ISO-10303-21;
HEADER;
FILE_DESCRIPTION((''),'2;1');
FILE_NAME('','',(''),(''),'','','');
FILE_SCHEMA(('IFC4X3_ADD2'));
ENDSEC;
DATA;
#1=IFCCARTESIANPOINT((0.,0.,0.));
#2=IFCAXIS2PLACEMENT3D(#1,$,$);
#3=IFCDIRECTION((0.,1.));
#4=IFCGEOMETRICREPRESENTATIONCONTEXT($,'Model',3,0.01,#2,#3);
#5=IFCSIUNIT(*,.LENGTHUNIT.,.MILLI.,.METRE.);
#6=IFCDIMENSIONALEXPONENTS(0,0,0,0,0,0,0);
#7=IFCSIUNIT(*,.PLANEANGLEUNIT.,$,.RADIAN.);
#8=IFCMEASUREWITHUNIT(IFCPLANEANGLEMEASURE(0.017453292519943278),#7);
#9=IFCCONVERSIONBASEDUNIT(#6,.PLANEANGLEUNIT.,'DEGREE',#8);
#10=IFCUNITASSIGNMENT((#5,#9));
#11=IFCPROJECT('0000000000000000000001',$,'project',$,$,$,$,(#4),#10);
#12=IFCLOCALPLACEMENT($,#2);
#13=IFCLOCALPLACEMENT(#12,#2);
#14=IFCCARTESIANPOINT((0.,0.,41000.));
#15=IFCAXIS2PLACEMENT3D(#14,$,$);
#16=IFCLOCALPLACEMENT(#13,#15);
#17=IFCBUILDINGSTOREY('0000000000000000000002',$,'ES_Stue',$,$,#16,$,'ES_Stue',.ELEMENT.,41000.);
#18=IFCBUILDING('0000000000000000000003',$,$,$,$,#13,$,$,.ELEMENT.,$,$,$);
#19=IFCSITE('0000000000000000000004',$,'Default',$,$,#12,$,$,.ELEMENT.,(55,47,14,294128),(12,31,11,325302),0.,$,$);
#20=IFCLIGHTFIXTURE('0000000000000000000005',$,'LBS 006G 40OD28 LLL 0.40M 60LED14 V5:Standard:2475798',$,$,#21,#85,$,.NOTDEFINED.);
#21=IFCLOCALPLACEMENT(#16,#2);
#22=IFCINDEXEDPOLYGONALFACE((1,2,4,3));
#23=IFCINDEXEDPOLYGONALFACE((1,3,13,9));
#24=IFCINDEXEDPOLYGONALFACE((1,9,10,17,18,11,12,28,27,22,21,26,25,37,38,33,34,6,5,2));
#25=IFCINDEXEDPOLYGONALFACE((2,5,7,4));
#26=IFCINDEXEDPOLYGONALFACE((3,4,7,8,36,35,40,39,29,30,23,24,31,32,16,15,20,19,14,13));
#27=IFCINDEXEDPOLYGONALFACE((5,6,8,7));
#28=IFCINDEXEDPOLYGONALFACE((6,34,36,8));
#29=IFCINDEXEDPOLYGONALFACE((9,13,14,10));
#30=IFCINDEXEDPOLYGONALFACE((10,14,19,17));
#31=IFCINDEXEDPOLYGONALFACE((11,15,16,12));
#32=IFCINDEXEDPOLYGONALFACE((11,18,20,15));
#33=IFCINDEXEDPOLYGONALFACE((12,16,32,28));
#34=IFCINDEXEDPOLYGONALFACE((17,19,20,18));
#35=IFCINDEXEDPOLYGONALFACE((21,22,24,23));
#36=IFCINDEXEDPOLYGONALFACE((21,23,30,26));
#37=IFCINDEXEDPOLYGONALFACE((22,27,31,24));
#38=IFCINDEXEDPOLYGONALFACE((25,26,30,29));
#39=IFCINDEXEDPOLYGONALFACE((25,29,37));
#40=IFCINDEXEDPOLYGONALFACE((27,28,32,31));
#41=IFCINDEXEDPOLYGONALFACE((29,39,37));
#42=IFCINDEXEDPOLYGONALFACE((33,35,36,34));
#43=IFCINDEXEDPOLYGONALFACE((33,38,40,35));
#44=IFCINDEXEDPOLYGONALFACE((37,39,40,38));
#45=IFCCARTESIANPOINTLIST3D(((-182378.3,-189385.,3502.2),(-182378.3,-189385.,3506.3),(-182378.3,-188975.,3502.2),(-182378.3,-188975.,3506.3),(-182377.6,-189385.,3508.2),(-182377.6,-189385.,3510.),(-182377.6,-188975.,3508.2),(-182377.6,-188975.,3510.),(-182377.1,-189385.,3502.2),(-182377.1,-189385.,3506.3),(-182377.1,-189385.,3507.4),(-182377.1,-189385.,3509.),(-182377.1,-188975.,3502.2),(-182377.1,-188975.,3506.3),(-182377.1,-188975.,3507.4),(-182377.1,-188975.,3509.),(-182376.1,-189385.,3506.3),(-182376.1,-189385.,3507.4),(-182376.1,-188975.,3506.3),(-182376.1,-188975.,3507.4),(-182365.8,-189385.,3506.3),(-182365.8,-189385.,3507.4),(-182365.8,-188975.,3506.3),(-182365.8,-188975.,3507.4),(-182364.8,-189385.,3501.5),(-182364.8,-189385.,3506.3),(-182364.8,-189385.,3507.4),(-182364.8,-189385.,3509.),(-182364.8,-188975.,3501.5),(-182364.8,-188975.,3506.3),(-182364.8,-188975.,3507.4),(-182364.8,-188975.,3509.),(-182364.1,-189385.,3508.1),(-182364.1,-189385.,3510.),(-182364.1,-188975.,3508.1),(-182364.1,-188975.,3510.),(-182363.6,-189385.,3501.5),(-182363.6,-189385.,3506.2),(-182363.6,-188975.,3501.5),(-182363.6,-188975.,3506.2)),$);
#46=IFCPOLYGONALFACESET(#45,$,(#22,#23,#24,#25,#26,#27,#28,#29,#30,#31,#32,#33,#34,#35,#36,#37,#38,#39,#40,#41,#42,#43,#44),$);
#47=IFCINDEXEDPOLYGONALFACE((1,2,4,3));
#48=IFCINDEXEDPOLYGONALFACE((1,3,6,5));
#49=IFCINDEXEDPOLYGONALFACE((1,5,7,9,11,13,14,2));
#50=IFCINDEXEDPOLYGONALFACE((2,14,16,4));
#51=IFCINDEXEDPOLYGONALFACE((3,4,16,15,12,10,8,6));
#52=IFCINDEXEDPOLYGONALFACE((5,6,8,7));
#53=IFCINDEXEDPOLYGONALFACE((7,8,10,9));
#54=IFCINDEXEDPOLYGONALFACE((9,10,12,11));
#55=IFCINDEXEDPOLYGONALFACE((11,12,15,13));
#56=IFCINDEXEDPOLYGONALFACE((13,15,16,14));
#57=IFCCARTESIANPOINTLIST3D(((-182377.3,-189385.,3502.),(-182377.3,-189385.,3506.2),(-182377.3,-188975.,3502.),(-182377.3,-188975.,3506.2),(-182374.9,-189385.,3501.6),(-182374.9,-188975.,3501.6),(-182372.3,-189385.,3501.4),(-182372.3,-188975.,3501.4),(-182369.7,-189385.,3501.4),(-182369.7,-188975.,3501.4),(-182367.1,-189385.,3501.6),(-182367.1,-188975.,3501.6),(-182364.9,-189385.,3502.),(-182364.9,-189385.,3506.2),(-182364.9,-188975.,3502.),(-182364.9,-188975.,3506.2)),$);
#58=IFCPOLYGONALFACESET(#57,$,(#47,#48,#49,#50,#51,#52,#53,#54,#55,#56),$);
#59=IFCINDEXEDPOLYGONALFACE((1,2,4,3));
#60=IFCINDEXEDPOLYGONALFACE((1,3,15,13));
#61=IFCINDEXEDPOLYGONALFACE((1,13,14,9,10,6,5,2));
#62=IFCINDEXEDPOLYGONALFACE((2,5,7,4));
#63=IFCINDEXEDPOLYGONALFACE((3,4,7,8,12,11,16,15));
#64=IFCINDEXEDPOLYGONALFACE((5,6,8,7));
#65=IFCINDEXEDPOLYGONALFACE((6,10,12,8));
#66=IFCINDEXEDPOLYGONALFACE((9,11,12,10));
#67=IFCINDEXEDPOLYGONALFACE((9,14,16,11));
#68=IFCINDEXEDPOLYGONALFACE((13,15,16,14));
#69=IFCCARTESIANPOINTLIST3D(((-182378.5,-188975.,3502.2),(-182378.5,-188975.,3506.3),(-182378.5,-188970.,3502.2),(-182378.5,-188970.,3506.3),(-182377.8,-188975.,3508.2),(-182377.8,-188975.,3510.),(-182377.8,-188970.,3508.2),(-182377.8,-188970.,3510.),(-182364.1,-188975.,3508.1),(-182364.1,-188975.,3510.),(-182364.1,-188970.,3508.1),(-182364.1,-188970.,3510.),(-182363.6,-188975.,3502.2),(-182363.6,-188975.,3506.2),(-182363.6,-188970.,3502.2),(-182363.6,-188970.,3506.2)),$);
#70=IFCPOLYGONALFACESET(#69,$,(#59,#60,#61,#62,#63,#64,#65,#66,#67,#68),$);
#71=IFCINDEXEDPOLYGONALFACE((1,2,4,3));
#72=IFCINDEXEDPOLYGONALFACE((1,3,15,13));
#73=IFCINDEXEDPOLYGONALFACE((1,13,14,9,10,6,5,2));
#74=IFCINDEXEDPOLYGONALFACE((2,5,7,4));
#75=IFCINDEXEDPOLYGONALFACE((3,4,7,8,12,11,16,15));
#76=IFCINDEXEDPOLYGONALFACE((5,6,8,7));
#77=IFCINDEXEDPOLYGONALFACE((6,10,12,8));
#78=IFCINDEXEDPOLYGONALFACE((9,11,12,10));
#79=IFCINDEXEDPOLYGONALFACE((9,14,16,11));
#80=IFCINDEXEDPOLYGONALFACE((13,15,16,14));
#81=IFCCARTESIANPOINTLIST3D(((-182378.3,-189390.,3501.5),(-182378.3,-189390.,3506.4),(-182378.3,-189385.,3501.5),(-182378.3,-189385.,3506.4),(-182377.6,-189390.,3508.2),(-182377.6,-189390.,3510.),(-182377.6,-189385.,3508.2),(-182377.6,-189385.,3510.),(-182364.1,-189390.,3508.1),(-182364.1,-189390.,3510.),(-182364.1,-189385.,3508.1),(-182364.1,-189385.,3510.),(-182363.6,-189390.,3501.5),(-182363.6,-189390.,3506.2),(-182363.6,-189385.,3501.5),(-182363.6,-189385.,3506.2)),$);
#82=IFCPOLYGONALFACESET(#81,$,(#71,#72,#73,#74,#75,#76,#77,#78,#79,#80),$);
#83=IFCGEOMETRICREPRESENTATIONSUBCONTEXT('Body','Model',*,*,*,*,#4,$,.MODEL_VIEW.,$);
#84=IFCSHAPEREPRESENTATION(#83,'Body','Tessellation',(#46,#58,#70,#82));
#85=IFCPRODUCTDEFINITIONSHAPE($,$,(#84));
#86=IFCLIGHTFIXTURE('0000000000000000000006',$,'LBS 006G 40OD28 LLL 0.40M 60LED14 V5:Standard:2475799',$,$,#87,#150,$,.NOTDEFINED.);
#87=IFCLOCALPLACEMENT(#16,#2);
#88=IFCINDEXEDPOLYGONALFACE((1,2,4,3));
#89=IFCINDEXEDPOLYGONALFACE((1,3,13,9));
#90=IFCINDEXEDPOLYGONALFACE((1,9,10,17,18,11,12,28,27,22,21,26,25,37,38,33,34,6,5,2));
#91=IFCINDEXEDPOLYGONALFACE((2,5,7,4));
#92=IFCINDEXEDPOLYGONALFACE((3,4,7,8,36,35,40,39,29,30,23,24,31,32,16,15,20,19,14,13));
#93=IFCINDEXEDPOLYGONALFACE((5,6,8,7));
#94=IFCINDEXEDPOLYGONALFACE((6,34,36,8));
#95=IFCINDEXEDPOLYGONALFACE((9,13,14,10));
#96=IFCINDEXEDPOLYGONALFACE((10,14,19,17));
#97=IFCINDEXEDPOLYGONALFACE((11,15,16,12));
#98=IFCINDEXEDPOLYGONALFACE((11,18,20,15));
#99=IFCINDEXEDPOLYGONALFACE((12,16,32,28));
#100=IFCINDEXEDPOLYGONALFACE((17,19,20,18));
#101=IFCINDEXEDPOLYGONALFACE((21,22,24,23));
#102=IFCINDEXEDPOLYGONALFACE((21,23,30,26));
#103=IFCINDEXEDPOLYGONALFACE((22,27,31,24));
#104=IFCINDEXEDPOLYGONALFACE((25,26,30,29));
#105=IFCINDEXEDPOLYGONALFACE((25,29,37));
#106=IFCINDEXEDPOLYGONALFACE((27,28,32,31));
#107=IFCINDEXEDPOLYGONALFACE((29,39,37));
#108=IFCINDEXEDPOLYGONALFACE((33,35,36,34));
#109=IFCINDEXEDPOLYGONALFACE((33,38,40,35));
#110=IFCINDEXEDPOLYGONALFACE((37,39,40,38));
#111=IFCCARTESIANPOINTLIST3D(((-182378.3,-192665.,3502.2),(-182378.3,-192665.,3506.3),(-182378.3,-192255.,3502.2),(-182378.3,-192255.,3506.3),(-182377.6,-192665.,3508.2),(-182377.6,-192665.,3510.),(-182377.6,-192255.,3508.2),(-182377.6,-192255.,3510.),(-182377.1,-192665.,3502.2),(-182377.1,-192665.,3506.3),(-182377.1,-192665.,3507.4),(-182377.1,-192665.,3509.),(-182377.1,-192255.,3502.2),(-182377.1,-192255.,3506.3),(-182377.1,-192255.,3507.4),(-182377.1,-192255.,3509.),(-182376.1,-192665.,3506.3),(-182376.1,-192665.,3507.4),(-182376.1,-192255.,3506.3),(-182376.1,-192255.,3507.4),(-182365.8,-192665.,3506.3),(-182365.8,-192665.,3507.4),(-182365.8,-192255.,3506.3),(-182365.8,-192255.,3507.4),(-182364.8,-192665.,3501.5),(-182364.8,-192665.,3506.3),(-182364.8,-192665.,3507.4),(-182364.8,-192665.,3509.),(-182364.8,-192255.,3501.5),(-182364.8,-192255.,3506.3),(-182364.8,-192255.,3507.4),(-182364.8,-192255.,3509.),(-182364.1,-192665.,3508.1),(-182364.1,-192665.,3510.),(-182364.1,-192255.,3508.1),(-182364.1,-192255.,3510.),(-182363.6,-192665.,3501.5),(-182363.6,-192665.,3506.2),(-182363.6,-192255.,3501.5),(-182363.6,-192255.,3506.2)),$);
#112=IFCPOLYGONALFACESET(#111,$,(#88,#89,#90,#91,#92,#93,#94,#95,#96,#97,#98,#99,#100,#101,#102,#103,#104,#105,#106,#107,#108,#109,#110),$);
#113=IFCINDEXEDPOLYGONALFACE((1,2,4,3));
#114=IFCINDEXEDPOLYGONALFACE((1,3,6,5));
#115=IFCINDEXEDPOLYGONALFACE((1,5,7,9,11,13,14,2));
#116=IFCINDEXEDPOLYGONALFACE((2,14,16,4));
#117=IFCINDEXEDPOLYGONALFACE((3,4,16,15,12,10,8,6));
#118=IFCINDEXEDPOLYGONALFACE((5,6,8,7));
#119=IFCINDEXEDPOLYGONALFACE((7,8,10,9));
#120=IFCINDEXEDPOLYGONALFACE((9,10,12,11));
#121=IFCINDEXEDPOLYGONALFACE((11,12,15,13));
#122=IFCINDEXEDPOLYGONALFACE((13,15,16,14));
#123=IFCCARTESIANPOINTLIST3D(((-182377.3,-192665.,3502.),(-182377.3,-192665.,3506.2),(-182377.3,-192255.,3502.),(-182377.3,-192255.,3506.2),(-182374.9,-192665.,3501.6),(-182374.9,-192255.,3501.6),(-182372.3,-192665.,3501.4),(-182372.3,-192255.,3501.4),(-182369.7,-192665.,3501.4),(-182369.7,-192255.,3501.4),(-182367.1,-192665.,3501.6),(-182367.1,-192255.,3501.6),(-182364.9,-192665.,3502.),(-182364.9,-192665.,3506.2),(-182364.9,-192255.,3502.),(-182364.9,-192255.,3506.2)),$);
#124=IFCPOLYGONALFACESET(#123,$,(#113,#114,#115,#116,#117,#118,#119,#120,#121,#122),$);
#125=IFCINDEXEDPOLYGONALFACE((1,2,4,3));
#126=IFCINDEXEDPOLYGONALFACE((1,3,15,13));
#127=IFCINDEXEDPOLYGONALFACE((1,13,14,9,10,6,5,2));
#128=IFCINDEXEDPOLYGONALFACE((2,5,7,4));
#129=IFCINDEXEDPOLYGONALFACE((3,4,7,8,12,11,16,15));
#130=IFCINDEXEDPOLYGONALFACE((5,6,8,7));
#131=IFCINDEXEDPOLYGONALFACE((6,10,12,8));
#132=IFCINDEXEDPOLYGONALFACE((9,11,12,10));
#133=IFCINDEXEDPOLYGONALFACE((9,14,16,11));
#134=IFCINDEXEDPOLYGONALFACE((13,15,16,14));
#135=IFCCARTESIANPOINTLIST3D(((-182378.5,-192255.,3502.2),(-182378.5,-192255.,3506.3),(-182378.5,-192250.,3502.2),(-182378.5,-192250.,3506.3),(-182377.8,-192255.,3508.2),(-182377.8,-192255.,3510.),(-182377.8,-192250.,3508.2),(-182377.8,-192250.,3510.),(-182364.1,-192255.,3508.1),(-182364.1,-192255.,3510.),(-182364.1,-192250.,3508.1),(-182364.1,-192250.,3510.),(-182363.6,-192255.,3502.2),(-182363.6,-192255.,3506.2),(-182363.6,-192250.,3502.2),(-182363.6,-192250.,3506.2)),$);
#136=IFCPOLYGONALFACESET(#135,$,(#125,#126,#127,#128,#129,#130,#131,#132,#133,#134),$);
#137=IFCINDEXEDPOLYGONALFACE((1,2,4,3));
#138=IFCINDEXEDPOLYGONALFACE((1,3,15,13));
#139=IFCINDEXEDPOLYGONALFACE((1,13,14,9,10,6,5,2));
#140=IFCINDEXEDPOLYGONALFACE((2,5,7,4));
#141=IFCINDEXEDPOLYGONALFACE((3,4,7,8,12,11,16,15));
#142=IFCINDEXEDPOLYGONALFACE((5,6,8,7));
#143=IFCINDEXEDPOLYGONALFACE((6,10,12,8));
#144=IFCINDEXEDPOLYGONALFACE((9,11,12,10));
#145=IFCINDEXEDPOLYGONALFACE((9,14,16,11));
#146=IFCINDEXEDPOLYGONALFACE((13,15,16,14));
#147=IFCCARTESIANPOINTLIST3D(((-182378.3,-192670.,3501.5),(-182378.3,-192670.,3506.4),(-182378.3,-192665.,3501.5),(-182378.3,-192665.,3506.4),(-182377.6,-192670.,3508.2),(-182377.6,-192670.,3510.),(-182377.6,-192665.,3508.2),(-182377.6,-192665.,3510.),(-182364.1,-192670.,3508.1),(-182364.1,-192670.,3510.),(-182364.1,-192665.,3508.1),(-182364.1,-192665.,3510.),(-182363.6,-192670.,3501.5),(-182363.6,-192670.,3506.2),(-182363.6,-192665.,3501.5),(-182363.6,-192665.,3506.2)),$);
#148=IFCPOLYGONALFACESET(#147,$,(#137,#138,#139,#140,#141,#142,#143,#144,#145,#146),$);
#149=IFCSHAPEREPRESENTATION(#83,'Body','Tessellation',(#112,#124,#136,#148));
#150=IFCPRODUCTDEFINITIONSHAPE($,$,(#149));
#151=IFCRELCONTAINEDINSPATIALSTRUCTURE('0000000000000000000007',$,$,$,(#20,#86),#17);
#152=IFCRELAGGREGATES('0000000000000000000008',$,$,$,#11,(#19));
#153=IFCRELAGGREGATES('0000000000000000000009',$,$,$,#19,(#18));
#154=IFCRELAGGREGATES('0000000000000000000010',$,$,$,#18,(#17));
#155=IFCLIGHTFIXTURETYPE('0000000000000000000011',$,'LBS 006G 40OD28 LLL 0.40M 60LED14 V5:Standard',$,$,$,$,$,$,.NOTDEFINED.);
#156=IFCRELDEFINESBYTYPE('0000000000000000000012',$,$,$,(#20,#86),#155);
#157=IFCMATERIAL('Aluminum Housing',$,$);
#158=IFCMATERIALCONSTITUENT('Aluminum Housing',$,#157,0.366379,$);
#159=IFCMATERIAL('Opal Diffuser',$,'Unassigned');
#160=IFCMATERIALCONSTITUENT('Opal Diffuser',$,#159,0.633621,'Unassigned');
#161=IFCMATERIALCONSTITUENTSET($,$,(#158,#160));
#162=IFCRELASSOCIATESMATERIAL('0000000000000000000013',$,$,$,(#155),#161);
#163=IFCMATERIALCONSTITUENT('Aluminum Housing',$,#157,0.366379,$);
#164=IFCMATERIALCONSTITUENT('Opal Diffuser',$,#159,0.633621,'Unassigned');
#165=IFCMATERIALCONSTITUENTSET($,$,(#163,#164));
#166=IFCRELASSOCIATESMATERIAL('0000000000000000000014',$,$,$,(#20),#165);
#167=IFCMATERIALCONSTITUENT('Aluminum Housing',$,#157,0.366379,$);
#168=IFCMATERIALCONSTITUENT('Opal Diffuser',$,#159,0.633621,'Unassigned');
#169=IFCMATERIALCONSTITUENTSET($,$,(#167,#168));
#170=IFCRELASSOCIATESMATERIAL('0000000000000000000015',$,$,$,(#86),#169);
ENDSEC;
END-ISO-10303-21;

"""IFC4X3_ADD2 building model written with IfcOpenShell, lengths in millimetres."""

from ifc_helpers import new_model, entity, si_unit, converted_unit, direction, frame, origin, place, context, subcontext, project, spatial, polyline, outline, extrude, source, transform, mapped, material, constituent, constituent_set, type_object, type_shapes, element, save


model = new_model("IFC4X3_ADD2")

# Units and contexts
model_context = context("Model", 3, precision=0.01, world=origin(), true_north=direction((0.0, 1.0)))
body_context = subcontext(model_context, "Body", "Model", "MODEL_VIEW")
ifc_project = project(units=[si_unit("LENGTHUNIT", "METRE", prefix="MILLI"), converted_unit("PLANEANGLEUNIT", "DEGREE", entity("IfcPlaneAngleMeasure", 0.017453292519943278), si_unit("PLANEANGLEUNIT", "RADIAN"), dimensions=[0, 0, 0, 0, 0, 0, 0])], contexts=[model_context])

# Site, building, storey
site_placement = place(None, origin())
site = spatial("IfcSite", under=ifc_project, at=site_placement, Name="Default", CompositionType="ELEMENT", RefLatitude=(55, 47, 14, 294128), RefLongitude=(12, 31, 11, 325302), RefElevation=0.0)
building_placement = place(site_placement, origin())
building = spatial("IfcBuilding", under=site, at=building_placement, CompositionType="ELEMENT")
storey_placement = place(building_placement, frame((0.0, 0.0, 41000.0)))
storey = spatial("IfcBuildingStorey", under=building, at=storey_placement, Name="ES_Stue", LongName="ES_Stue", CompositionType="ELEMENT", Elevation=41000.0)

# Light fixtures
ifc_material_1 = material(Name="Aluminum Housing")
ifc_material_2 = material(Name="Opal Diffuser", Category="Unassigned")
ifc_constituent_1 = constituent(ifc_material_1, Name="Aluminum Housing", fraction=0.366379)
ifc_constituent_2 = constituent(ifc_material_2, Name="Opal Diffuser", Category="Unassigned", fraction=0.633621)
ifc_constituent_set_1 = constituent_set(constituents=[ifc_constituent_1, ifc_constituent_2])
light_fixture_type = type_object("IfcLightFixtureType", Name="LBS 006G 40OD28 LLL 0.40M 60LED14 V5:Standard", PredefinedType="NOTDEFINED", material=ifc_constituent_set_1)
shared_shape_1 = source(origin(), body_context, "Body", "SweptSolid", [
    extrude(outline(polyline([(-5.0, -6.1), (-5.0, -7.4), (-0.3, -7.4), (1.7, -6.8), (3.5, -6.8), (3.5, 6.7), (1.8, 6.7), (-0.1, 7.3), (-4.2, 7.3), (-4.2, 6.2), (-0.1, 6.2), (-0.1, 5.2), (0.9, 5.2), (0.9, 6.2), (2.5, 6.2), (2.5, -6.1), (0.9, -6.1), (0.9, -5.1), (-0.1, -5.1), (-0.1, -6.1), (-5.0, -6.1)])), frame((-205.0, 0.1, 3.5), z_axis=(-1.0, 0.0, 0.0), x_axis=(0.0, 0.0, -1.0)), (0.0, 0.0, -1.0), 410.0),
    extrude(outline(polyline([(-0.8, -6.2), (3.4, -6.2), (3.4, 6.2), (-0.8, 6.2), (-1.2, 3.9), (-1.4, 1.4), (-1.4, -1.3), (-1.2, -3.9), (-0.8, -6.2)])), frame((-205.0, 0.0, 7.2), z_axis=(1.0, 0.0, 0.0), x_axis=(0.0, 0.0, -1.0)), (0.0, 0.0, 1.0), 410.0),
    extrude(outline(polyline([(-4.4, -7.5), (-0.3, -7.5), (1.5, -6.8), (3.3, -6.8), (3.3, 6.9), (1.5, 6.9), (-0.5, 7.4), (-4.4, 7.4), (-4.4, -7.5)])), frame((205.0, 0.0, 3.3), z_axis=(1.0, 0.0, 0.0), x_axis=(0.0, 0.0, -1.0)), (0.0, 0.0, 1.0), 5.0),
    extrude(outline(polyline([(-5.0, -7.4), (-0.1, -7.4), (1.7, -6.7), (3.5, -6.7), (3.5, 6.8), (1.6, 6.8), (-0.3, 7.3), (-5.0, 7.3), (-5.0, -7.4)])), frame((-210.0, 0.2, 3.5), z_axis=(1.0, 0.0, 0.0), x_axis=(0.0, 0.0, -1.0)), (0.0, 0.0, 1.0), 5.0),
])
type_shapes(light_fixture_type, [shared_shape_1])
ifc_constituent_3 = constituent(ifc_material_1, Name="Aluminum Housing", fraction=0.366379)
ifc_constituent_4 = constituent(ifc_material_2, Name="Opal Diffuser", Category="Unassigned", fraction=0.633621)
ifc_constituent_set_2 = constituent_set(constituents=[ifc_constituent_3, ifc_constituent_4])
light_fixture_1_placement = place(storey_placement, frame((-182371.0, -189180.0, 3510.0), z_axis=(0.0, 0.0, -1.0), x_axis=(0.0, 1.0, 0.0)))
element("IfcLightFixture", 1, at=light_fixture_1_placement, inside=storey, type_object=light_fixture_type, material=ifc_constituent_set_2, Name="LBS 006G 40OD28 LLL 0.40M 60LED14 V5:Standard:2475798", PredefinedType="NOTDEFINED", context=body_context, shape_type="MappedRepresentation", body=[
    mapped(shared_shape_1, transform((0.0, 0.0, 0.0), scale=1.0)),
])
ifc_constituent_5 = constituent(ifc_material_1, Name="Aluminum Housing", fraction=0.366379)
ifc_constituent_6 = constituent(ifc_material_2, Name="Opal Diffuser", Category="Unassigned", fraction=0.633621)
ifc_constituent_set_3 = constituent_set(constituents=[ifc_constituent_5, ifc_constituent_6])
light_fixture_2_placement = place(storey_placement, frame((-182371.0, -192460.0, 3510.0), z_axis=(0.0, 0.0, -1.0), x_axis=(0.0, 1.0, 0.0)))
element("IfcLightFixture", 2, at=light_fixture_2_placement, inside=storey, type_object=light_fixture_type, material=ifc_constituent_set_3, Name="LBS 006G 40OD28 LLL 0.40M 60LED14 V5:Standard:2475799", PredefinedType="NOTDEFINED", context=body_context, shape_type="MappedRepresentation", body=[
    mapped(shared_shape_1, transform((0.0, 0.0, 0.0), scale=1.0)),
])

save(model, "model.ifc")
